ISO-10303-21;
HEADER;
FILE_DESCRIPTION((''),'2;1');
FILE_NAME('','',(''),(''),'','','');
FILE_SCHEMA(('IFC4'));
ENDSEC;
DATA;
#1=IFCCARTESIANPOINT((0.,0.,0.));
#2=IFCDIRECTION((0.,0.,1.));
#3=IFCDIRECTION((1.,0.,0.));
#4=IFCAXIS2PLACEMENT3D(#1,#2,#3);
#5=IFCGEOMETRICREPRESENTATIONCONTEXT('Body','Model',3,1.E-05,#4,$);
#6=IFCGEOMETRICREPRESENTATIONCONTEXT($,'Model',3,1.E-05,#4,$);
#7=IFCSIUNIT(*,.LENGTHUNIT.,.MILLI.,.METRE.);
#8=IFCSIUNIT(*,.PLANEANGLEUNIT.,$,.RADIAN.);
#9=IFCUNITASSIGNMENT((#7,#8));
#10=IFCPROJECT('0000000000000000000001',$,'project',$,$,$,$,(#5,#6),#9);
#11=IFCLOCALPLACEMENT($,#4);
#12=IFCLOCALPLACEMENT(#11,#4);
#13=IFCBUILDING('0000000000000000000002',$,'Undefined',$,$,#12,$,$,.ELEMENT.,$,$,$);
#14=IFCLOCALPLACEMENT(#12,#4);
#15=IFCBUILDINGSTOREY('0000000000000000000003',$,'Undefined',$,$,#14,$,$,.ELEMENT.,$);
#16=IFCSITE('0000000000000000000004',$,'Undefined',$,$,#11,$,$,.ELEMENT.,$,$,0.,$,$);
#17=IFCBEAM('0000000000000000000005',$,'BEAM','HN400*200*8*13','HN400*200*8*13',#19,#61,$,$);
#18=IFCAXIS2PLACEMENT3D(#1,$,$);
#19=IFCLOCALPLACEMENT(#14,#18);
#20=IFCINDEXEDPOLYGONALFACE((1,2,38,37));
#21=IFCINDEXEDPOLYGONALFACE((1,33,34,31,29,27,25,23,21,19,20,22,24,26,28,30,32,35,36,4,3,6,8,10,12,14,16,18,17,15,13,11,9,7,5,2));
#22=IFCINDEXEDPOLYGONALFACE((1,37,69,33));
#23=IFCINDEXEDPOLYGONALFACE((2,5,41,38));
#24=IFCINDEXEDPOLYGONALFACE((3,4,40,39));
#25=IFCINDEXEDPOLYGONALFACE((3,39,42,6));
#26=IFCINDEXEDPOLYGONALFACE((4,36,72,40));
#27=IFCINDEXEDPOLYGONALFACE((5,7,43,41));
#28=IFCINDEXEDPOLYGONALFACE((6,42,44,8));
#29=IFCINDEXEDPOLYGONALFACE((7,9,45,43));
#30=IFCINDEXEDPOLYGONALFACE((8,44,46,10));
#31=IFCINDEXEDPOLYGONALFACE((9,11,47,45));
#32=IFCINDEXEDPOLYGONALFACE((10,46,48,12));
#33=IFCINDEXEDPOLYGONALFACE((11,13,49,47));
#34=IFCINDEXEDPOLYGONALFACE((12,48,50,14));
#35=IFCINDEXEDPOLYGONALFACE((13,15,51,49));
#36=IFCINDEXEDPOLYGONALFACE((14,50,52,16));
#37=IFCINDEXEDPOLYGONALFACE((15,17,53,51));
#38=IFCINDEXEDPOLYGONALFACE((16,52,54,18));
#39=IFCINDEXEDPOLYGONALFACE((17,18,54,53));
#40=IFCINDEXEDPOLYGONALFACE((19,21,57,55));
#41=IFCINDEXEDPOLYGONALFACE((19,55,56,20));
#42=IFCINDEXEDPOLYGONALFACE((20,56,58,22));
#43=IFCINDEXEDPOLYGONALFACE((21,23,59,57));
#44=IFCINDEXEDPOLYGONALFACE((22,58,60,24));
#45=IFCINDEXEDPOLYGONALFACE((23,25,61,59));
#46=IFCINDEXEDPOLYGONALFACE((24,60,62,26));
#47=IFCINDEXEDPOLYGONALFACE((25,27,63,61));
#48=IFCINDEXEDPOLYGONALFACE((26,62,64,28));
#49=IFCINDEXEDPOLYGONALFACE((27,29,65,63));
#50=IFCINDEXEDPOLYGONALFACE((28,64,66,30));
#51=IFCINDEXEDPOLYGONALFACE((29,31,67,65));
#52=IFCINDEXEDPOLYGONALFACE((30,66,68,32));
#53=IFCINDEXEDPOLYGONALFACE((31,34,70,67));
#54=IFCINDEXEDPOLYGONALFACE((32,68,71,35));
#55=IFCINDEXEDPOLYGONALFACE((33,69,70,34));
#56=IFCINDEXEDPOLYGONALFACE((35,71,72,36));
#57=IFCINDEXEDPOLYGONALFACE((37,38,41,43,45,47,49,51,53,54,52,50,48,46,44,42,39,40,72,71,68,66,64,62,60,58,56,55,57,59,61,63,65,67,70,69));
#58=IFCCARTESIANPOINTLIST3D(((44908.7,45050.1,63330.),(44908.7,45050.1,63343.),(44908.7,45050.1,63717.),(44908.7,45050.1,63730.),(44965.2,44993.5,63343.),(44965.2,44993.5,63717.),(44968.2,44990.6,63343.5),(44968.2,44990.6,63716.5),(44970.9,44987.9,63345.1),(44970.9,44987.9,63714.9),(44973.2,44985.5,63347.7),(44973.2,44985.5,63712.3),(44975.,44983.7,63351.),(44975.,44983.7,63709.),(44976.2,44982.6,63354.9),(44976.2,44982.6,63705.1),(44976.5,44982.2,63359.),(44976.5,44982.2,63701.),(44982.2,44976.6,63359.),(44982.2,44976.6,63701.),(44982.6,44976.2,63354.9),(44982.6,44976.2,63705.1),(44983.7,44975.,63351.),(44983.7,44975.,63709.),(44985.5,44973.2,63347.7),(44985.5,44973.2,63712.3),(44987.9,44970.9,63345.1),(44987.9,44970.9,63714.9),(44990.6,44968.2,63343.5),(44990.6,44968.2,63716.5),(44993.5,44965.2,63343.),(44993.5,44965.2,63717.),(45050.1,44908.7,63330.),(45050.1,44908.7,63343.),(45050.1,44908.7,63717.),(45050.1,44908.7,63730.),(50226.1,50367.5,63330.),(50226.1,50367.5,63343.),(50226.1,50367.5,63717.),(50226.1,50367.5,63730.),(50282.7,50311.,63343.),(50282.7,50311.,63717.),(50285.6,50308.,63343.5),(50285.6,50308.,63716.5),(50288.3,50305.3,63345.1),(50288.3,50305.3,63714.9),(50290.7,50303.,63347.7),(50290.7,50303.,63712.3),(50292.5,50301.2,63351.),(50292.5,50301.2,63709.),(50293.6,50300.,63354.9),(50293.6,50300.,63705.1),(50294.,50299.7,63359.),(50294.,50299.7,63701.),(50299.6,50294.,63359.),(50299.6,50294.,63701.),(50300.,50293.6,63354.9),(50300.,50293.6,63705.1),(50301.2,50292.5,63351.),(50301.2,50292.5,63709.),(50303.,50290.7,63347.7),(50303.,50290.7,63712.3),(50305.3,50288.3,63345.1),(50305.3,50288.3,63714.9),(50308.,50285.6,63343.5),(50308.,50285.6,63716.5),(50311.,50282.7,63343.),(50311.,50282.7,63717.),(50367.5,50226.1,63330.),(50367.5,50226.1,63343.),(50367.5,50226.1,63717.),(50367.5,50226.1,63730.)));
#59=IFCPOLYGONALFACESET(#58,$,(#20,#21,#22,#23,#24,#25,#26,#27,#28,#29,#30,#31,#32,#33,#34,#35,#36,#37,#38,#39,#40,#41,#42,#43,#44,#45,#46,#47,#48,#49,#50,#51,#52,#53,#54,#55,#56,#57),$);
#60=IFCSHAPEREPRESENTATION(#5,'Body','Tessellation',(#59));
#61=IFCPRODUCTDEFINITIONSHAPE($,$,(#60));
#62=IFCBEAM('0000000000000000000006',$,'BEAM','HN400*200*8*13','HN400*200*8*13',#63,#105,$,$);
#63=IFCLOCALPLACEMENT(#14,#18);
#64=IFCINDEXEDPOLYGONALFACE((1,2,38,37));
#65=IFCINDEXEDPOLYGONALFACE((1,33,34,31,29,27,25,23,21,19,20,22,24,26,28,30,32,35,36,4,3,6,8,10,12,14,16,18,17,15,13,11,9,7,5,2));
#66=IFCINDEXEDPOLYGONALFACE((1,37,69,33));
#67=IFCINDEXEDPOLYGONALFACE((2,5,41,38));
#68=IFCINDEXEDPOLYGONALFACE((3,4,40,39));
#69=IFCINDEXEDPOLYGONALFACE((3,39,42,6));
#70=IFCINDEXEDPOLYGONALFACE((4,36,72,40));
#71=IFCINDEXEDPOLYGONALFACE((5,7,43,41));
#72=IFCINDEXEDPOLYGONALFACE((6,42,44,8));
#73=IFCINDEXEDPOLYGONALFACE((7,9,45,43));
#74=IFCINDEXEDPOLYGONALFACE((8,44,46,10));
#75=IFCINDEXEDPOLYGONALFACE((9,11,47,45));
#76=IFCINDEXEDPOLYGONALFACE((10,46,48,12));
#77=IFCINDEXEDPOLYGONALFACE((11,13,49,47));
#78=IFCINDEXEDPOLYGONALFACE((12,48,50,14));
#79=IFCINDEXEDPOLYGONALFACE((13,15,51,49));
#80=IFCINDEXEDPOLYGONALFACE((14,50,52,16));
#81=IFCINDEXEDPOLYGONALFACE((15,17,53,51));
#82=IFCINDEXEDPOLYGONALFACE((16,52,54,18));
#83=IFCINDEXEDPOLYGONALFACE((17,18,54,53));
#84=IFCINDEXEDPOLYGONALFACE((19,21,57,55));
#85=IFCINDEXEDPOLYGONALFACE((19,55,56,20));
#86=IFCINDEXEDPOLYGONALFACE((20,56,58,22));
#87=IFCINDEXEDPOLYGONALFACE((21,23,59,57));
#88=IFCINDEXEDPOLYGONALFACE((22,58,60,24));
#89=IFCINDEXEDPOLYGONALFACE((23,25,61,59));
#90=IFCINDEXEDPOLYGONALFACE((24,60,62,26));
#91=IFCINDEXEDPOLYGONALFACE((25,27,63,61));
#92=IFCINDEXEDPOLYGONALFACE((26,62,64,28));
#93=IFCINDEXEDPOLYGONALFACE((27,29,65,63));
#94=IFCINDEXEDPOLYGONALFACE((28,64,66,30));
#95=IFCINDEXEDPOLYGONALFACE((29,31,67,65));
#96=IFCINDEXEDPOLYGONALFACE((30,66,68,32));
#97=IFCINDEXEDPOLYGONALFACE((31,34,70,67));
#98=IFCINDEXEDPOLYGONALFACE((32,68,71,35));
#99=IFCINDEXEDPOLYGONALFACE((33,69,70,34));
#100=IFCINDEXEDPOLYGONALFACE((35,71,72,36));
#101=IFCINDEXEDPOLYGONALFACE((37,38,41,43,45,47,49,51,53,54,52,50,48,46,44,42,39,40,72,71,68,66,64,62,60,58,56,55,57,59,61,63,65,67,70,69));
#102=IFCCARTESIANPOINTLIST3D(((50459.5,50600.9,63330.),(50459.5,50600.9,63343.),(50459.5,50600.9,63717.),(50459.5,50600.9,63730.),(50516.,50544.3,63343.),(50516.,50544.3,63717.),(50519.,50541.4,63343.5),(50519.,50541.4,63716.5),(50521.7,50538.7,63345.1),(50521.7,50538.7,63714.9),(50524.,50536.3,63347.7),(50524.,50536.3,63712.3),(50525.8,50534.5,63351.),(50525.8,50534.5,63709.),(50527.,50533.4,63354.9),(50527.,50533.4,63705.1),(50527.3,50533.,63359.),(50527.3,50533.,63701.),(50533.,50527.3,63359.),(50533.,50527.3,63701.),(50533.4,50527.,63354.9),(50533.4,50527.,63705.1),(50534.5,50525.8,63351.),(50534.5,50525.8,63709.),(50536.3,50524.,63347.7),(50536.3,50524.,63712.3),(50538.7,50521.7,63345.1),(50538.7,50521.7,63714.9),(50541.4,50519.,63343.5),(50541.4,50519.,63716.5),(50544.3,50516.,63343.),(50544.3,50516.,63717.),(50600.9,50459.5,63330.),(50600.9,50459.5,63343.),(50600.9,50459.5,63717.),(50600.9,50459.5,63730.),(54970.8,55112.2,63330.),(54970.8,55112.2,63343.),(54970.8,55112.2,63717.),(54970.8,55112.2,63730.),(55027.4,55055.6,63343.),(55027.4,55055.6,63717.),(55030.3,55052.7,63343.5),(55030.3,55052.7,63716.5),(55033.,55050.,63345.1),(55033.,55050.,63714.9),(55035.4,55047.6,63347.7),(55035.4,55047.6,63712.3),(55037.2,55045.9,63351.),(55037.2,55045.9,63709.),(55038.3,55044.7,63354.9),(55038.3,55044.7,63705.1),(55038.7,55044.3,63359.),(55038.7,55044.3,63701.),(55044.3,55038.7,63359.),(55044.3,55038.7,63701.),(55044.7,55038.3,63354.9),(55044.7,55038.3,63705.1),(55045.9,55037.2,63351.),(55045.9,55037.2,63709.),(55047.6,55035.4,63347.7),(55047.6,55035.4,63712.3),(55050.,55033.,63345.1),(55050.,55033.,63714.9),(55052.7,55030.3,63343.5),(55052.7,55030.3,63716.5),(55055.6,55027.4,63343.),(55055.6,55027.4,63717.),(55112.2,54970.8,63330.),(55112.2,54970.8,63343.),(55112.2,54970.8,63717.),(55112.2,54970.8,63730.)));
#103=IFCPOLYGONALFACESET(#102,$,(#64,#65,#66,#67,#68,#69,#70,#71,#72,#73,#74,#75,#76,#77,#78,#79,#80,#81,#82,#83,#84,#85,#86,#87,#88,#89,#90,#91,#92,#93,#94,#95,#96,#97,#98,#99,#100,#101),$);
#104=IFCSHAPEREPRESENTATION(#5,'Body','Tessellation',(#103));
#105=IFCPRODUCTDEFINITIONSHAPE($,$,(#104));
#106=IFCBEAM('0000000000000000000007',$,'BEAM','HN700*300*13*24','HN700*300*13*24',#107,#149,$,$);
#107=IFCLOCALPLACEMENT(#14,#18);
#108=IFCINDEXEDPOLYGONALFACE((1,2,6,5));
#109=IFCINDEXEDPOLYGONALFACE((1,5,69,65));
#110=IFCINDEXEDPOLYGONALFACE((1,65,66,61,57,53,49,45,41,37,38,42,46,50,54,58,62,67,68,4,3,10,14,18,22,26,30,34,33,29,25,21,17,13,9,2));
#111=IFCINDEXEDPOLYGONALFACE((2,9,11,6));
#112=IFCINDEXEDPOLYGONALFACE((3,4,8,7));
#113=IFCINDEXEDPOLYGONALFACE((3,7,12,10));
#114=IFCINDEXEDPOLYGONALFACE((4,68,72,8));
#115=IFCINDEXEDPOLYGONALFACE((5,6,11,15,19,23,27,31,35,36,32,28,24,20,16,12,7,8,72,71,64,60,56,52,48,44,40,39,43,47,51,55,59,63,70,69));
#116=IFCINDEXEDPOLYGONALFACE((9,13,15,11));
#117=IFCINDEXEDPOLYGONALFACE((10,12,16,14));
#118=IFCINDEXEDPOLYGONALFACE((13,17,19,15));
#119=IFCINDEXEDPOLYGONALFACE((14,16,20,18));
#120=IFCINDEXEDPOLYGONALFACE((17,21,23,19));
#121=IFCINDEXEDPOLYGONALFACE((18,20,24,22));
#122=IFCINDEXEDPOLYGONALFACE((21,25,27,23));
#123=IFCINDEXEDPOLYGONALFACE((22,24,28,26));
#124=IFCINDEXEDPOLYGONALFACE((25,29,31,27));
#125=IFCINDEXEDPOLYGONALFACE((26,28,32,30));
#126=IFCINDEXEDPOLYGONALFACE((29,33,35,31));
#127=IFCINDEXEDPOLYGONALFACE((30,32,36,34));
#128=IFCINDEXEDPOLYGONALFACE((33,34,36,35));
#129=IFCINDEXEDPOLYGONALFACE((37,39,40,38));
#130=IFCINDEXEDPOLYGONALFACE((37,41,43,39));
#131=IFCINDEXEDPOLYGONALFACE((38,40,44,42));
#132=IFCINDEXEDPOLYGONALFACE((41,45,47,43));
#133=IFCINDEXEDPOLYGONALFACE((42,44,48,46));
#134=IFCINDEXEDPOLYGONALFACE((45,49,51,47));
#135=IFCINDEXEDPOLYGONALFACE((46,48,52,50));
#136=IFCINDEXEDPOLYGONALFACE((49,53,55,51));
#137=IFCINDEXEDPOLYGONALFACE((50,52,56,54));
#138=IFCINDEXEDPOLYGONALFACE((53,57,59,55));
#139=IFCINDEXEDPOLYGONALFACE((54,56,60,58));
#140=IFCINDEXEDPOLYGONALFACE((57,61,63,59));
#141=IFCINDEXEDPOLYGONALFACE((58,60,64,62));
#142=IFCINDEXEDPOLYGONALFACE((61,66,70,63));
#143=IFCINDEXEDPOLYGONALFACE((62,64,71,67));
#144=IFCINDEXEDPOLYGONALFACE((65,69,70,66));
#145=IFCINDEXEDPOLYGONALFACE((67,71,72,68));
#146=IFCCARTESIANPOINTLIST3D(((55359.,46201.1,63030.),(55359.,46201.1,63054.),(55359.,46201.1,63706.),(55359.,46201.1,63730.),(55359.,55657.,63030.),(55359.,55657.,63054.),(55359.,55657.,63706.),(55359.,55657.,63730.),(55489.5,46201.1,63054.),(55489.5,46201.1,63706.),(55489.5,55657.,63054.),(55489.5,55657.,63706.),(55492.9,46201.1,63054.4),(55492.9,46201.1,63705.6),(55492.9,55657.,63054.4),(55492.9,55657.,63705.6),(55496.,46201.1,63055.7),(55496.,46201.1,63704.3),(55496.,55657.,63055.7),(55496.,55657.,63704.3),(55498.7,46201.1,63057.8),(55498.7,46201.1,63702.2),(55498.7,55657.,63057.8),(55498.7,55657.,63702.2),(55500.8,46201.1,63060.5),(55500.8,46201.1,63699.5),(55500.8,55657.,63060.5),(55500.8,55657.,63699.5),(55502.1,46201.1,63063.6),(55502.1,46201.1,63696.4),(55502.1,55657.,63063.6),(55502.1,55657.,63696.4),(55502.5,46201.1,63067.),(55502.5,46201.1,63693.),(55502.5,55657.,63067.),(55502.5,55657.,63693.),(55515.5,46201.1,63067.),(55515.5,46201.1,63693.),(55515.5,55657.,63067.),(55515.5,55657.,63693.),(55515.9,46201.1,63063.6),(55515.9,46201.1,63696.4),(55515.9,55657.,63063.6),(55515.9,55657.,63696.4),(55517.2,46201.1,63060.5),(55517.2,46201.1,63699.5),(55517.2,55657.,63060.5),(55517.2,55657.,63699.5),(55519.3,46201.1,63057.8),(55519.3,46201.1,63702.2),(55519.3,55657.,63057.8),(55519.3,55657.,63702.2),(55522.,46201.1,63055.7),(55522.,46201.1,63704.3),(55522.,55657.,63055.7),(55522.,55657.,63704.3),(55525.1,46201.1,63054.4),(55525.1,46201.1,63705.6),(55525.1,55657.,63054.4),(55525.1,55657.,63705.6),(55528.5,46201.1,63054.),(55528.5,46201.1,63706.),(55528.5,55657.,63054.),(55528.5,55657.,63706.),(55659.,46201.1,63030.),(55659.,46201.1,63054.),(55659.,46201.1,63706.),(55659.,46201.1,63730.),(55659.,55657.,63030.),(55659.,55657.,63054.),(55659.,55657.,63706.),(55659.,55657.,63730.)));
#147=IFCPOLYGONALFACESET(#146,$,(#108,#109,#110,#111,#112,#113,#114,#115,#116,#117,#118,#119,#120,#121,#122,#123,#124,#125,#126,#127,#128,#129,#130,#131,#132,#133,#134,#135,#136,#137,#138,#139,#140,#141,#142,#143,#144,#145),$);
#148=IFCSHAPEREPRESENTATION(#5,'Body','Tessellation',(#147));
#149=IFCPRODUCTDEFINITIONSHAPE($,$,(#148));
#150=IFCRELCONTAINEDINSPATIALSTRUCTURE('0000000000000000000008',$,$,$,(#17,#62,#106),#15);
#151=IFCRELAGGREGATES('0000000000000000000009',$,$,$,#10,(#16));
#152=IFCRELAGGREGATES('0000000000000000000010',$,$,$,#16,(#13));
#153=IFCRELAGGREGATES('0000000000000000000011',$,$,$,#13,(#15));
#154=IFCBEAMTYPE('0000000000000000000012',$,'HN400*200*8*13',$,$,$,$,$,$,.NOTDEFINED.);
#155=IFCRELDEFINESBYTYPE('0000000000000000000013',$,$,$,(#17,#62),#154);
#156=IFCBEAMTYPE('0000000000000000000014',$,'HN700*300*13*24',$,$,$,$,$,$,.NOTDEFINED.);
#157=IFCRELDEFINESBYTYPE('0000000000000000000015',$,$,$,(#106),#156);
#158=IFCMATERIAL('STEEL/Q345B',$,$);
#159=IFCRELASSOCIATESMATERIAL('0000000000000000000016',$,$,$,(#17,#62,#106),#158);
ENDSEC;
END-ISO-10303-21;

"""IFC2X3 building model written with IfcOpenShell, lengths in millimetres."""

from ifc_helpers import new_model, si_unit, frame, origin_with_axes, origin_2d_with_axis, place, context, project, spatial, i_section, extrude, material, type_object, element, save


model = new_model("IFC2X3")

# Units and contexts
model_context_1 = context("Model", 3, precision=1e-05, world=origin_with_axes(), identifier="Body")
model_context_2 = context("Model", 3, precision=1e-05, world=origin_with_axes())
ifc_project = project(units=[si_unit("LENGTHUNIT", "METRE", prefix="MILLI"), si_unit("PLANEANGLEUNIT", "RADIAN")], contexts=[model_context_1, model_context_2])

# Site, building, storey
site_placement = place(None, origin_with_axes())
site = spatial("IfcSite", under=ifc_project, at=site_placement, Name="Undefined", CompositionType="ELEMENT", RefElevation=0.0)
building_placement = place(site_placement, origin_with_axes())
building = spatial("IfcBuilding", under=site, at=building_placement, Name="Undefined", CompositionType="ELEMENT")
storey_placement = place(building_placement, origin_with_axes())
storey = spatial("IfcBuildingStorey", under=building, at=storey_placement, Name="Undefined", CompositionType="ELEMENT")

# Beams
ifc_material_1 = material(Name="STEEL/Q345B")
beam_type_1 = type_object("IfcBeamType", Name="HN400*200*8*13", PredefinedType="NOTDEFINED")
beam_1_placement = place(storey_placement, frame((50413.5, 50413.5, 63530.0), z_axis=(0.0, 0.0, 1.0), x_axis=(-0.707107, -0.707107, 0.0)))
element("IfcBeam", 1, at=beam_1_placement, inside=storey, type_object=beam_type_1, material=ifc_material_1, Name="BEAM", Description="HN400*200*8*13", ObjectType="HN400*200*8*13", context=model_context_1, shape_type="SweptSolid", body=[
    extrude(i_section(OverallWidth=200.0, OverallDepth=400.0, WebThickness=8.0, FlangeThickness=13.0, FilletRadius=16.0, at=origin_2d_with_axis()), frame((7685.0, 0.0, 0.0), z_axis=(-1.0, 0.0, 0.0), x_axis=(0.0, -1.0, 0.0)), (0.0, 0.0, 1.0), 7520.0),
])
beam_2_placement = place(storey_placement, frame((55148.7, 55148.7, 63530.0), z_axis=(0.0, 0.0, 1.0), x_axis=(-0.707107, -0.707107, 0.0)))
element("IfcBeam", 2, at=beam_2_placement, inside=storey, type_object=beam_type_1, material=ifc_material_1, Name="BEAM", Description="HN400*200*8*13", ObjectType="HN400*200*8*13", context=model_context_1, shape_type="SweptSolid", body=[
    extrude(i_section(OverallWidth=200.0, OverallDepth=400.0, WebThickness=8.0, FlangeThickness=13.0, FilletRadius=16.0, at=origin_2d_with_axis()), frame((6531.7, 0.0, 0.0), z_axis=(-1.0, 0.0, 0.0), x_axis=(0.0, -1.0, 0.0)), (0.0, 0.0, 1.0), 6380.0),
])
beam_type_2 = type_object("IfcBeamType", Name="HN700*300*13*24", PredefinedType="NOTDEFINED")
beam_3_placement = place(storey_placement, frame((55509.0, 46201.1, 63380.0), z_axis=(0.0, 0.0, 1.0), x_axis=(0.0, 1.0, 0.0)))
element("IfcBeam", 3, at=beam_3_placement, inside=storey, type_object=beam_type_2, material=ifc_material_1, Name="BEAM", Description="HN700*300*13*24", ObjectType="HN700*300*13*24", context=model_context_1, shape_type="SweptSolid", body=[
    extrude(i_section(OverallWidth=300.0, OverallDepth=700.0, WebThickness=13.0, FlangeThickness=24.0, FilletRadius=13.0, at=origin_2d_with_axis()), frame((9455.9, 0.0, 0.0), z_axis=(-1.0, 0.0, 0.0), x_axis=(0.0, -1.0, 0.0)), (0.0, 0.0, 1.0), 9455.9),
])

save(model, "model.ifc")
